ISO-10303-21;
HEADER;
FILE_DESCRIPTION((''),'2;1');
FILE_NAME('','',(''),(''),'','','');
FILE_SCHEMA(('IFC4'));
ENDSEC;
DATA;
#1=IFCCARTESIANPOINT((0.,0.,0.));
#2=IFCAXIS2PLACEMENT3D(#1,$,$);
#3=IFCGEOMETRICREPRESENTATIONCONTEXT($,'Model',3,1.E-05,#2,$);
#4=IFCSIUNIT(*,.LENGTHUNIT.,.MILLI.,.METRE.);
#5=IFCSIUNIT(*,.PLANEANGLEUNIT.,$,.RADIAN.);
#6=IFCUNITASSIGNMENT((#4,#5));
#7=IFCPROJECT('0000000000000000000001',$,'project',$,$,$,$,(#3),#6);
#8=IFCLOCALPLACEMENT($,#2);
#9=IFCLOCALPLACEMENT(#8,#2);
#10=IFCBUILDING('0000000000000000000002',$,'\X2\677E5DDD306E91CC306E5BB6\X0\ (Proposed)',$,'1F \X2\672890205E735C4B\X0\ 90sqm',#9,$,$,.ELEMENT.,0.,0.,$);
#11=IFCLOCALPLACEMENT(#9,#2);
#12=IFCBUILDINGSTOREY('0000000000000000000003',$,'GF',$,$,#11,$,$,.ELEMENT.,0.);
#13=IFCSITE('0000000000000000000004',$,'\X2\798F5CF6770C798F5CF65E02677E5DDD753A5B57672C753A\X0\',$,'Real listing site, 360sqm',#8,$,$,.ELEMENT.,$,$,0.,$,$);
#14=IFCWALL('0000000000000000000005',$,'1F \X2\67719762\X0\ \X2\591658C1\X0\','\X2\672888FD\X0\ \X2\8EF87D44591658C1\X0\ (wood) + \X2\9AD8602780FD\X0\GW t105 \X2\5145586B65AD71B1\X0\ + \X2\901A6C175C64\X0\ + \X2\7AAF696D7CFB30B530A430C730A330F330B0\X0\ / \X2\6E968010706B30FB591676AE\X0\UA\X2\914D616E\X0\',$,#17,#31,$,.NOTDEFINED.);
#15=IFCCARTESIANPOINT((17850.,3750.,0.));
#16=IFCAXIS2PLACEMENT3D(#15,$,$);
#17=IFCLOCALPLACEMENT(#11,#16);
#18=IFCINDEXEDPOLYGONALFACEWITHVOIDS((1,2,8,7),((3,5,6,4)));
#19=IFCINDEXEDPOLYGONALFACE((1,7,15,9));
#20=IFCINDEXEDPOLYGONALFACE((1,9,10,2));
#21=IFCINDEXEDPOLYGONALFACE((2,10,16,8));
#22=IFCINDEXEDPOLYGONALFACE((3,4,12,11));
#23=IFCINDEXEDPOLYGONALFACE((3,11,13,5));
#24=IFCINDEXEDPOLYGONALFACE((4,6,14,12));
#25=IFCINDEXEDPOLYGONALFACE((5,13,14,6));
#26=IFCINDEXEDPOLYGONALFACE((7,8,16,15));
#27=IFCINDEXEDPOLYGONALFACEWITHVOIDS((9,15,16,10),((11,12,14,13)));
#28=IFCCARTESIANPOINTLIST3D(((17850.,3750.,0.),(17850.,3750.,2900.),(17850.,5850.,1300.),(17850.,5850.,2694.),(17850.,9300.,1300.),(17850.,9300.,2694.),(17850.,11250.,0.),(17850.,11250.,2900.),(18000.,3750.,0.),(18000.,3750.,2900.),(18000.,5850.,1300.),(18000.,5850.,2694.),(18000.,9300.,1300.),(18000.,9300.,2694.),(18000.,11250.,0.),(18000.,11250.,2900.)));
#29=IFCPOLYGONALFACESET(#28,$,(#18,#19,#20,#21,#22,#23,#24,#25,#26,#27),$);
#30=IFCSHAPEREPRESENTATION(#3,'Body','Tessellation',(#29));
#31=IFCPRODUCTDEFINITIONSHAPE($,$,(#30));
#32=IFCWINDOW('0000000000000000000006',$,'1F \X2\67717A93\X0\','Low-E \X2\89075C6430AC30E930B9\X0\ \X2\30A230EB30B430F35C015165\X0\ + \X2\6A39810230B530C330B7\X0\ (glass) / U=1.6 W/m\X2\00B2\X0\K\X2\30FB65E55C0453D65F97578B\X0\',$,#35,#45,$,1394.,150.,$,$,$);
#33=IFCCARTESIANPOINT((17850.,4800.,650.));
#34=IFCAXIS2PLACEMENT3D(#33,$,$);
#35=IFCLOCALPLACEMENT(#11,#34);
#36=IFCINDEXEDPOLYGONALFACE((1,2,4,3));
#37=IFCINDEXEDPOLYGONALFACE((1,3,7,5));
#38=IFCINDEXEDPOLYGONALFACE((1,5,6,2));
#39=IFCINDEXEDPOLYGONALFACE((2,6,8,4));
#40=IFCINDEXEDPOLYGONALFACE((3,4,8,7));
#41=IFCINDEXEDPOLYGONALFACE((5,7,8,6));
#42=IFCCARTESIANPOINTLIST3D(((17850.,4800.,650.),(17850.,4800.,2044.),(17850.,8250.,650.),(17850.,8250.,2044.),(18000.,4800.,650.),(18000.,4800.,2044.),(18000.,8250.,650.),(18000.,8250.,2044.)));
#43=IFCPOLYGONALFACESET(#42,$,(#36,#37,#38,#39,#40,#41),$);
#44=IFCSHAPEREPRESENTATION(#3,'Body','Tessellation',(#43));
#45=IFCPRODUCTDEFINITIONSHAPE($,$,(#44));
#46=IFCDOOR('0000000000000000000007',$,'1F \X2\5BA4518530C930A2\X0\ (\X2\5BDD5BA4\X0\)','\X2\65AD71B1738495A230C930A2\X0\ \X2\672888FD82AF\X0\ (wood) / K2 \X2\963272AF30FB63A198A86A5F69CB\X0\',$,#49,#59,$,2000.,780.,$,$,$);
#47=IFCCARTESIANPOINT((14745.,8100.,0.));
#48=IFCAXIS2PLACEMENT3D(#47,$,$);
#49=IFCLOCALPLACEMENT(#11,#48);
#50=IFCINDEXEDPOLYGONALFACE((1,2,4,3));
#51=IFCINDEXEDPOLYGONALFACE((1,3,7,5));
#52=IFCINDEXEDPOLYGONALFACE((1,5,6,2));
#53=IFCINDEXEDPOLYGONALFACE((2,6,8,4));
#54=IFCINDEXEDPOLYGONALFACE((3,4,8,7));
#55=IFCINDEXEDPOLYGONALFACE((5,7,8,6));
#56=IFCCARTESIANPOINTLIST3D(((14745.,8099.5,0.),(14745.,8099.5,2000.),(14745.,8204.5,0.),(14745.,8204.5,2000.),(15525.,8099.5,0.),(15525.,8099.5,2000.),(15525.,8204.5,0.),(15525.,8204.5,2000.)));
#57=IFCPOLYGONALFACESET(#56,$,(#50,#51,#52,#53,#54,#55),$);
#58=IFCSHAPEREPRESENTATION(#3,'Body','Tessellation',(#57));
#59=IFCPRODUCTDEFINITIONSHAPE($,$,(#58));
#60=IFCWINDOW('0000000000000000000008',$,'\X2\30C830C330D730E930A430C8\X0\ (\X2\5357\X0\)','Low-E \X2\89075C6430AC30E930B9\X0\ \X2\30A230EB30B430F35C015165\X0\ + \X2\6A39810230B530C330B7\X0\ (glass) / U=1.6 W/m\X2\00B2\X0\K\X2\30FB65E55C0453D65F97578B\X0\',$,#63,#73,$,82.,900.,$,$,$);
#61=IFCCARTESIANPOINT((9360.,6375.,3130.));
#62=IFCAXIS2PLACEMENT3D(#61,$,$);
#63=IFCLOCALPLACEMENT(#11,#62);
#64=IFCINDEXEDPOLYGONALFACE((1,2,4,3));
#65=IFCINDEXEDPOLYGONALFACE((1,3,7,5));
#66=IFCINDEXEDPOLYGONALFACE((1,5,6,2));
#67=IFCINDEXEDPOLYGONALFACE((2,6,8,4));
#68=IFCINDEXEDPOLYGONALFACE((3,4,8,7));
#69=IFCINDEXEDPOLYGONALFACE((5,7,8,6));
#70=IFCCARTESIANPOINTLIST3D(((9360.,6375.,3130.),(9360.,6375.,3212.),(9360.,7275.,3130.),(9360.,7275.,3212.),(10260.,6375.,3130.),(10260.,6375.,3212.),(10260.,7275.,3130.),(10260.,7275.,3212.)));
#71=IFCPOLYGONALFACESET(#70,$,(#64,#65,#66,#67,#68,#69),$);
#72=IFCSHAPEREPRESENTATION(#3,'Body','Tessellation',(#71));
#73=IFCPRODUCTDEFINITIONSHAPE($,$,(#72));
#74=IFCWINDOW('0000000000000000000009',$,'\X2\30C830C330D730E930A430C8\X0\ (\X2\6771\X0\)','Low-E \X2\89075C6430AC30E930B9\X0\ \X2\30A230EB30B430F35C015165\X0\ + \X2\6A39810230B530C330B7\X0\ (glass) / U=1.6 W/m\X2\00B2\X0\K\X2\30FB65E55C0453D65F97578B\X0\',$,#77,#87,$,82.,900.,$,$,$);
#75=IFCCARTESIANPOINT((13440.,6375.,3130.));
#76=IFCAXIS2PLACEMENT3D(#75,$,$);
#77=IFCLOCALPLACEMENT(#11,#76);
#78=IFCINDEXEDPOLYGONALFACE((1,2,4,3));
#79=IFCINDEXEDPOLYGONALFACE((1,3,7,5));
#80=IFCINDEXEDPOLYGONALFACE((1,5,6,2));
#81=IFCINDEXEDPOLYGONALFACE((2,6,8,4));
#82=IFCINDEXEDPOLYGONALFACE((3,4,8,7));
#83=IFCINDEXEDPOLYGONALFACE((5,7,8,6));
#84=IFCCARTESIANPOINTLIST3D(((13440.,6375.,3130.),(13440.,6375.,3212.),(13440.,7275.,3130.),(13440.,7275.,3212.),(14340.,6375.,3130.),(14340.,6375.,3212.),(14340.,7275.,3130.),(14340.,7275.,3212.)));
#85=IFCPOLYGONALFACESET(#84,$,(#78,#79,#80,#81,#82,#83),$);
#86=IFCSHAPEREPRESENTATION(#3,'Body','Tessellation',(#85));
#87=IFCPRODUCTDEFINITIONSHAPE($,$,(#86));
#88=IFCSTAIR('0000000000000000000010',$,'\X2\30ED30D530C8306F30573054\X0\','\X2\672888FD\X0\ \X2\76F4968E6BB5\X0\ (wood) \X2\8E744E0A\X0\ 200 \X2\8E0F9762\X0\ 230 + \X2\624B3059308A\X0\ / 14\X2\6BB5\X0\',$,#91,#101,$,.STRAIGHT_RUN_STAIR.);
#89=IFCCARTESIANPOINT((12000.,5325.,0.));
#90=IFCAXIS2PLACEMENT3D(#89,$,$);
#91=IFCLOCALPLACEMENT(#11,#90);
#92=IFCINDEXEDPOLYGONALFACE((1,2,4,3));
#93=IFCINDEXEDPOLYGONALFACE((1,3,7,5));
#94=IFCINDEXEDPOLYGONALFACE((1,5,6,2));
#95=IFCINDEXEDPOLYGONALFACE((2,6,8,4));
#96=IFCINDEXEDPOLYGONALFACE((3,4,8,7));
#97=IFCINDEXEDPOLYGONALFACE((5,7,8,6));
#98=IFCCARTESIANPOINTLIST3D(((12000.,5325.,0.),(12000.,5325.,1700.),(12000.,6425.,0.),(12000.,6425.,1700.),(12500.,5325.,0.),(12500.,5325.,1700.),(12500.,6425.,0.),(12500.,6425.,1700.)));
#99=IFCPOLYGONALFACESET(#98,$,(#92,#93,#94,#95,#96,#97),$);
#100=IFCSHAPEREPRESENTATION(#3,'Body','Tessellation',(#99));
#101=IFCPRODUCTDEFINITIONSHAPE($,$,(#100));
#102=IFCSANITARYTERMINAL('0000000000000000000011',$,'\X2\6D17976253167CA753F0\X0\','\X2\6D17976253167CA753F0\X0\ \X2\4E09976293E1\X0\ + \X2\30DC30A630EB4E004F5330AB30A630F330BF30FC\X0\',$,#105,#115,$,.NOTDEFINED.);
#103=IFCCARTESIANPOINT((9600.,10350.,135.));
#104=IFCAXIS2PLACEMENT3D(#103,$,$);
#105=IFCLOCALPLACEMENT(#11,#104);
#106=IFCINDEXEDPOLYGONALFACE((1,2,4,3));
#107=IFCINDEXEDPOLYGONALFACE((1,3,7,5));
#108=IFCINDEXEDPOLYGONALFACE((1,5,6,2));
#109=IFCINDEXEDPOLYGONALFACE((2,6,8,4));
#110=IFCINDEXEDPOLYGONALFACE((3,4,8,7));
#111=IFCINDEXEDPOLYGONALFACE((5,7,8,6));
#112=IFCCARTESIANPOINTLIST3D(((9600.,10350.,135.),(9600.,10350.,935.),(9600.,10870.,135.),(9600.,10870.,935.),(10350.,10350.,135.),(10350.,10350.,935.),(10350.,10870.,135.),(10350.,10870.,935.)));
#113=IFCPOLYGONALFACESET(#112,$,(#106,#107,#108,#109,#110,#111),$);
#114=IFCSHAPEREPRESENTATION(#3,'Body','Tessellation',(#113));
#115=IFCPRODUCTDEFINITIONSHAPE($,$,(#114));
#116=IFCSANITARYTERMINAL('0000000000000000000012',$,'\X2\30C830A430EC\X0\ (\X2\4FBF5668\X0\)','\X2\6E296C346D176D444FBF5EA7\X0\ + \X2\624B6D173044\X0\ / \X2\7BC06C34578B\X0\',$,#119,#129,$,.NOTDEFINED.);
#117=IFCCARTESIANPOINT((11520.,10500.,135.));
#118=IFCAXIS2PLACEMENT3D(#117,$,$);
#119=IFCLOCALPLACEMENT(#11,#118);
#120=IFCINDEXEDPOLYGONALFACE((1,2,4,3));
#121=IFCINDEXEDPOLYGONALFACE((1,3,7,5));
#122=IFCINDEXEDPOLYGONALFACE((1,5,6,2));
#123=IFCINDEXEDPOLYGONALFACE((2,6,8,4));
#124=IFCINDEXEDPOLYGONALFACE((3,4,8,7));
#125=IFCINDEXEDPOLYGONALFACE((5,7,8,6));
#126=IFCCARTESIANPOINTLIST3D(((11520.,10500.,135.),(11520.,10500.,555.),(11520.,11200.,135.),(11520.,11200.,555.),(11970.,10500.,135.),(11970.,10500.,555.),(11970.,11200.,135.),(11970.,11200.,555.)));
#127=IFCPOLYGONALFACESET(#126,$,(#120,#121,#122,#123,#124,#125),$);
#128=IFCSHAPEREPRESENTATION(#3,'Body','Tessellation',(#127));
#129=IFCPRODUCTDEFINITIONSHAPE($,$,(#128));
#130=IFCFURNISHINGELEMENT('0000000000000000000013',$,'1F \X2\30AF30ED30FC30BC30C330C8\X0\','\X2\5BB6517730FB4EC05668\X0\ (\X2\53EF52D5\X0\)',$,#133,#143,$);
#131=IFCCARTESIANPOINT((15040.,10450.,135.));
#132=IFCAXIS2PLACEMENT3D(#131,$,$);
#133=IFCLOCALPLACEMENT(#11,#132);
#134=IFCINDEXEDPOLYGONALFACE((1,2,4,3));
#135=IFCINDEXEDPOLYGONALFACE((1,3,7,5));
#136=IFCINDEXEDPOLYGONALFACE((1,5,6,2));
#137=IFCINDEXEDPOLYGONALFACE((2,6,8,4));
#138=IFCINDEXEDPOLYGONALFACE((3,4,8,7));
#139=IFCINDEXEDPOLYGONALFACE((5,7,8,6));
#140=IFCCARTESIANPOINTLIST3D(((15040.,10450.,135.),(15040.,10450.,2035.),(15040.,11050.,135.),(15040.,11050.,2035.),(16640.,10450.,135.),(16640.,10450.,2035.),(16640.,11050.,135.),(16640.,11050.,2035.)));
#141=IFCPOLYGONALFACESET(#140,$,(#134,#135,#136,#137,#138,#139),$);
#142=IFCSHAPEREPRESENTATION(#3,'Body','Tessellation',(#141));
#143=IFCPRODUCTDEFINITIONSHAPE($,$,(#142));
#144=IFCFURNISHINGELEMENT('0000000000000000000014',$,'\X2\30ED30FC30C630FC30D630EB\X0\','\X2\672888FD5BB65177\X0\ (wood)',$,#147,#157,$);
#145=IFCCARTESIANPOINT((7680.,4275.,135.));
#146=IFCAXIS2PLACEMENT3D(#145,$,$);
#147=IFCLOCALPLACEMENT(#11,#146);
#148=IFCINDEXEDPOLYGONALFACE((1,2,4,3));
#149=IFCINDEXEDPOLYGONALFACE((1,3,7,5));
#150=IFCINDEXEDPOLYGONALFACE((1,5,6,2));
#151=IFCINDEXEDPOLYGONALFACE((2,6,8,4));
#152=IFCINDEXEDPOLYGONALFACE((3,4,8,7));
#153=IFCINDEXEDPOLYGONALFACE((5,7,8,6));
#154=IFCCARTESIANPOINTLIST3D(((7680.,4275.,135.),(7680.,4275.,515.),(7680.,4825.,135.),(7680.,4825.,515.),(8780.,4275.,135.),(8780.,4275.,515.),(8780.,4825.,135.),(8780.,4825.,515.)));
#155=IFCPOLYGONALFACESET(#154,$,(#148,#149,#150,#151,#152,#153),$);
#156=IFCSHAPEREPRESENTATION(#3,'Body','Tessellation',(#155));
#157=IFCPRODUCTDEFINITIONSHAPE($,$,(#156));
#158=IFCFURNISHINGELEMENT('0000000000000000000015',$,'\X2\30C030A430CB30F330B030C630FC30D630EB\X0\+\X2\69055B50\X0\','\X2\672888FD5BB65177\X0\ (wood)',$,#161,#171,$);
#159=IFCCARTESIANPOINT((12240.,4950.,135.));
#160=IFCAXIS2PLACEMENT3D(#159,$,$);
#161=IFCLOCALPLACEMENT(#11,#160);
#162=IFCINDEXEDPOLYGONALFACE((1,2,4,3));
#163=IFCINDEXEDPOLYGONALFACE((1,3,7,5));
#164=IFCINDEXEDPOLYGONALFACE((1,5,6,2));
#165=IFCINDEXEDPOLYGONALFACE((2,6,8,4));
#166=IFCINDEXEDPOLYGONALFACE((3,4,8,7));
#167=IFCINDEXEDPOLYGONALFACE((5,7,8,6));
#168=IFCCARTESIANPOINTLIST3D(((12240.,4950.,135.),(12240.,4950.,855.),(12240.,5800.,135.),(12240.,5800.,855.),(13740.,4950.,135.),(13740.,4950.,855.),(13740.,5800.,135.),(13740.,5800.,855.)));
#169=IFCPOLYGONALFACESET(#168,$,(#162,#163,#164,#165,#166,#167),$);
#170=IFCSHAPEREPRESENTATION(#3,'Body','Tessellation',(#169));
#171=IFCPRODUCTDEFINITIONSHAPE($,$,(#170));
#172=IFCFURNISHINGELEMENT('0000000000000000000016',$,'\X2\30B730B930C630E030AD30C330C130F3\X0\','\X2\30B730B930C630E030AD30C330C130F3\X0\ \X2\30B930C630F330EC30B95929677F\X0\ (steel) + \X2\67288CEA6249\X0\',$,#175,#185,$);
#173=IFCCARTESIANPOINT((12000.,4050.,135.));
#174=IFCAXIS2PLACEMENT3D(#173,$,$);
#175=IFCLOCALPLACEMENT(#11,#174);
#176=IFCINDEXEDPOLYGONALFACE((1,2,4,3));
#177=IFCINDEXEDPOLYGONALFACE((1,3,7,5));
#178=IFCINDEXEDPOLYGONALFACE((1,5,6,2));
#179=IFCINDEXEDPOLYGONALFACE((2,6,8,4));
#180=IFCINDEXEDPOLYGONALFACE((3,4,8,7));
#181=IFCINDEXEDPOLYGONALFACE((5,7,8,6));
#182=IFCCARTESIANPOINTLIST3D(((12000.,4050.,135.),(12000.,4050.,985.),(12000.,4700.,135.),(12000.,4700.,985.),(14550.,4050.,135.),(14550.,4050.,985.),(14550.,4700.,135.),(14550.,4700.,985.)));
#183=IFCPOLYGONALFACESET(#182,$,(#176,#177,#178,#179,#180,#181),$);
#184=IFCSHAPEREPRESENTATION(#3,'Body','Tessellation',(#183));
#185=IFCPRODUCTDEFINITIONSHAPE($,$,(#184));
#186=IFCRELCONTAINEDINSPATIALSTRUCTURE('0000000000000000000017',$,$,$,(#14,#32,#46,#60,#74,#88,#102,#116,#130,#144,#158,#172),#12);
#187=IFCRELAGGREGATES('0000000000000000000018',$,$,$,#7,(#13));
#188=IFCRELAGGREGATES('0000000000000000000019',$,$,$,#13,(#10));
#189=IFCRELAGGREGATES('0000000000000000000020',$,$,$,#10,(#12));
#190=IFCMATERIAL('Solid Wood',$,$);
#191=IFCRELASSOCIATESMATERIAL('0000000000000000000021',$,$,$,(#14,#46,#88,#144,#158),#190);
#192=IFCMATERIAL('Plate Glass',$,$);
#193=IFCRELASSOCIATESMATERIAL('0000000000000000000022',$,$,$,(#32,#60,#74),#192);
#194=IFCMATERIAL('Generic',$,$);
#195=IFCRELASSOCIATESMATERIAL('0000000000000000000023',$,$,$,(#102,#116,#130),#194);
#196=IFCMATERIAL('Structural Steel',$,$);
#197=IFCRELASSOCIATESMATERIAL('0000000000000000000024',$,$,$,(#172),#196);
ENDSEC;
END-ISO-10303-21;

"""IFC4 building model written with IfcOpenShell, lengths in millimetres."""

from ifc_helpers import new_model, si_unit, frame, frame_2d, origin, place, context, project, spatial, rectangle, extrude, material, element, fill, save


model = new_model("IFC4")

# Units and contexts
model_context = context("Model", 3, precision=1e-05, world=origin())
ifc_project = project(units=[si_unit("LENGTHUNIT", "METRE", prefix="MILLI"), si_unit("PLANEANGLEUNIT", "RADIAN")], contexts=[model_context])

# Site, building, storey
site_placement = place(None, origin())
site = spatial("IfcSite", under=ifc_project, at=site_placement, Name="福島県福島市松川町字本町", ObjectType="Real listing site, 360sqm", CompositionType="ELEMENT", RefElevation=0.0)
building_placement = place(site_placement, origin())
building = spatial("IfcBuilding", under=site, at=building_placement, Name="松川の里の家 (Proposed)", ObjectType="1F 木造平屋 90sqm", CompositionType="ELEMENT", ElevationOfRefHeight=0.0, ElevationOfTerrain=0.0)
storey_placement = place(building_placement, origin())
storey = spatial("IfcBuildingStorey", under=building, at=storey_placement, Name="GF", CompositionType="ELEMENT", Elevation=0.0)

# Wall, opening, window
ifc_material_1 = material(Name="Solid Wood")
wall_1_placement = place(storey_placement, frame((17850.0, 3750.0, 0.0)))
wall_1 = element("IfcWall", 1, at=wall_1_placement, inside=storey, material=ifc_material_1, Name="1F 東面 外壁", Description="木製 軸組外壁 (wood) + 高性能GW t105 充填断熱 + 通気層 + 窯業系サイディング / 準耐火・外皮UA配慮", PredefinedType="NOTDEFINED", context=model_context, shape_type="SweptSolid", body=[
    extrude(rectangle(XDim=150.0, YDim=7500.0, at=frame_2d((75.0, 3750.0))), frame((17850.0, 3750.0, 0.0)), (0.0, 0.0, 1.0), 2900.0),
])
opening_placement = place(storey_placement, frame((17850.0, 4800.0, 650.0)))
opening = element("IfcOpeningElement", 2, at=opening_placement, cuts=wall_1, PredefinedType="NOTDEFINED", context=model_context, shape_type="SweptSolid", body=[
    extrude(rectangle(XDim=150.0, YDim=3450.0, at=frame_2d((75.0, 1725.0))), frame((17850.0, 4800.0, 650.0)), (0.0, 0.0, 1.0), 1394.0),
])
ifc_material_2 = material(Name="Plate Glass")
window_1_placement = place(storey_placement, frame((17850.0, 4800.0, 650.0)))
window_1 = element("IfcWindow", 3, at=window_1_placement, inside=storey, material=ifc_material_2, Name="1F 東窓", Description="Low-E 複層ガラス アルゴン封入 + 樹脂サッシ (glass) / U=1.6 W/m²K・日射取得型", OverallHeight=1394.0, OverallWidth=150.0, context=model_context, shape_type="SweptSolid", body=[
    extrude(rectangle(XDim=150.0, YDim=3450.0, at=frame_2d((75.0, 1725.0))), frame((17850.0, 4800.0, 650.0)), (0.0, 0.0, 1.0), 1394.0),
])
fill(opening, window_1)

# Door
door_placement = place(storey_placement, frame((14745.0, 8100.0, 0.0)))
element("IfcDoor", 4, at=door_placement, inside=storey, material=ifc_material_1, Name="1F 室内ドア (寝室)", Description="断熱玄関ドア 木製芯 (wood) / K2 防犯・採風機構", OverallHeight=2000.0, OverallWidth=780.0, context=model_context, shape_type="SweptSolid", body=[
    extrude(rectangle(XDim=780.0, YDim=105.0, at=frame_2d((390.0, 52.0))), frame((14745.0, 8100.0, 0.0)), (0.0, 0.0, 1.0), 2000.0),
])

# Windows
window_2_placement = place(storey_placement, frame((9360.0, 6375.0, 3130.0)))
element("IfcWindow", 5, at=window_2_placement, inside=storey, material=ifc_material_2, Name="トップライト (南)", Description="Low-E 複層ガラス アルゴン封入 + 樹脂サッシ (glass) / U=1.6 W/m²K・日射取得型", OverallHeight=82.0, OverallWidth=900.0, context=model_context, shape_type="SweptSolid", body=[
    extrude(rectangle(XDim=900.0, YDim=900.0, at=frame_2d((450.0, 450.0))), frame((9360.0, 6375.0, 3130.0)), (0.0, 0.0, 1.0), 82.0),
])
window_3_placement = place(storey_placement, frame((13440.0, 6375.0, 3130.0)))
element("IfcWindow", 6, at=window_3_placement, inside=storey, material=ifc_material_2, Name="トップライト (東)", Description="Low-E 複層ガラス アルゴン封入 + 樹脂サッシ (glass) / U=1.6 W/m²K・日射取得型", OverallHeight=82.0, OverallWidth=900.0, context=model_context, shape_type="SweptSolid", body=[
    extrude(rectangle(XDim=900.0, YDim=900.0, at=frame_2d((450.0, 450.0))), frame((13440.0, 6375.0, 3130.0)), (0.0, 0.0, 1.0), 82.0),
])

# Stair
stair_placement = place(storey_placement, frame((12000.0, 5325.0, 0.0)))
element("IfcStair", 7, at=stair_placement, inside=storey, material=ifc_material_1, Name="ロフトはしご", Description="木製 直階段 (wood) 蹴上 200 踏面 230 + 手すり / 14段", PredefinedType="STRAIGHT_RUN_STAIR", context=model_context, shape_type="SweptSolid", body=[
    extrude(rectangle(XDim=500.0, YDim=1100.0, at=frame_2d((250.0, 550.0))), frame((12000.0, 5325.0, 0.0)), (0.0, 0.0, 1.0), 1700.0),
])

# Sanitary terminals
ifc_material_3 = material(Name="Generic")
sanitary_terminal_1_placement = place(storey_placement, frame((9600.0, 10350.0, 135.0)))
element("IfcSanitaryTerminal", 8, at=sanitary_terminal_1_placement, inside=storey, material=ifc_material_3, Name="洗面化粧台", Description="洗面化粧台 三面鏡 + ボウル一体カウンター", PredefinedType="NOTDEFINED", context=model_context, shape_type="SweptSolid", body=[
    extrude(rectangle(XDim=750.0, YDim=520.0, at=frame_2d((375.0, 260.0))), frame((9600.0, 10350.0, 135.0)), (0.0, 0.0, 1.0), 800.0),
])
sanitary_terminal_2_placement = place(storey_placement, frame((11520.0, 10500.0, 135.0)))
element("IfcSanitaryTerminal", 9, at=sanitary_terminal_2_placement, inside=storey, material=ifc_material_3, Name="トイレ (便器)", Description="温水洗浄便座 + 手洗い / 節水型", PredefinedType="NOTDEFINED", context=model_context, shape_type="SweptSolid", body=[
    extrude(rectangle(XDim=450.0, YDim=700.0, at=frame_2d((225.0, 350.0))), frame((11520.0, 10500.0, 135.0)), (0.0, 0.0, 1.0), 420.0),
])

# Furnishing elements
furnishing_1_placement = place(storey_placement, frame((15040.0, 10450.0, 135.0)))
element("IfcFurnishingElement", 10, at=furnishing_1_placement, inside=storey, material=ifc_material_3, Name="1F クローゼット", Description="家具・什器 (可動)", context=model_context, shape_type="SweptSolid", body=[
    extrude(rectangle(XDim=1600.0, YDim=600.0, at=frame_2d((800.0, 300.0))), frame((15040.0, 10450.0, 135.0)), (0.0, 0.0, 1.0), 1900.0),
])
furnishing_2_placement = place(storey_placement, frame((7680.0, 4275.0, 135.0)))
element("IfcFurnishingElement", 11, at=furnishing_2_placement, inside=storey, material=ifc_material_1, Name="ローテーブル", Description="木製家具 (wood)", context=model_context, shape_type="SweptSolid", body=[
    extrude(rectangle(XDim=1100.0, YDim=550.0, at=frame_2d((550.0, 275.0))), frame((7680.0, 4275.0, 135.0)), (0.0, 0.0, 1.0), 380.0),
])
furnishing_3_placement = place(storey_placement, frame((12240.0, 4950.0, 135.0)))
element("IfcFurnishingElement", 12, at=furnishing_3_placement, inside=storey, material=ifc_material_1, Name="ダイニングテーブル+椅子", Description="木製家具 (wood)", context=model_context, shape_type="SweptSolid", body=[
    extrude(rectangle(XDim=1500.0, YDim=850.0, at=frame_2d((750.0, 425.0))), frame((12240.0, 4950.0, 135.0)), (0.0, 0.0, 1.0), 720.0),
])
ifc_material_4 = material(Name="Structural Steel")
furnishing_4_placement = place(storey_placement, frame((12000.0, 4050.0, 135.0)))
element("IfcFurnishingElement", 13, at=furnishing_4_placement, inside=storey, material=ifc_material_4, Name="システムキッチン", Description="システムキッチン ステンレス天板 (steel) + 木質扉", context=model_context, shape_type="SweptSolid", body=[
    extrude(rectangle(XDim=2550.0, YDim=650.0, at=frame_2d((1275.0, 325.0))), frame((12000.0, 4050.0, 135.0)), (0.0, 0.0, 1.0), 850.0),
])

save(model, "model.ifc")
